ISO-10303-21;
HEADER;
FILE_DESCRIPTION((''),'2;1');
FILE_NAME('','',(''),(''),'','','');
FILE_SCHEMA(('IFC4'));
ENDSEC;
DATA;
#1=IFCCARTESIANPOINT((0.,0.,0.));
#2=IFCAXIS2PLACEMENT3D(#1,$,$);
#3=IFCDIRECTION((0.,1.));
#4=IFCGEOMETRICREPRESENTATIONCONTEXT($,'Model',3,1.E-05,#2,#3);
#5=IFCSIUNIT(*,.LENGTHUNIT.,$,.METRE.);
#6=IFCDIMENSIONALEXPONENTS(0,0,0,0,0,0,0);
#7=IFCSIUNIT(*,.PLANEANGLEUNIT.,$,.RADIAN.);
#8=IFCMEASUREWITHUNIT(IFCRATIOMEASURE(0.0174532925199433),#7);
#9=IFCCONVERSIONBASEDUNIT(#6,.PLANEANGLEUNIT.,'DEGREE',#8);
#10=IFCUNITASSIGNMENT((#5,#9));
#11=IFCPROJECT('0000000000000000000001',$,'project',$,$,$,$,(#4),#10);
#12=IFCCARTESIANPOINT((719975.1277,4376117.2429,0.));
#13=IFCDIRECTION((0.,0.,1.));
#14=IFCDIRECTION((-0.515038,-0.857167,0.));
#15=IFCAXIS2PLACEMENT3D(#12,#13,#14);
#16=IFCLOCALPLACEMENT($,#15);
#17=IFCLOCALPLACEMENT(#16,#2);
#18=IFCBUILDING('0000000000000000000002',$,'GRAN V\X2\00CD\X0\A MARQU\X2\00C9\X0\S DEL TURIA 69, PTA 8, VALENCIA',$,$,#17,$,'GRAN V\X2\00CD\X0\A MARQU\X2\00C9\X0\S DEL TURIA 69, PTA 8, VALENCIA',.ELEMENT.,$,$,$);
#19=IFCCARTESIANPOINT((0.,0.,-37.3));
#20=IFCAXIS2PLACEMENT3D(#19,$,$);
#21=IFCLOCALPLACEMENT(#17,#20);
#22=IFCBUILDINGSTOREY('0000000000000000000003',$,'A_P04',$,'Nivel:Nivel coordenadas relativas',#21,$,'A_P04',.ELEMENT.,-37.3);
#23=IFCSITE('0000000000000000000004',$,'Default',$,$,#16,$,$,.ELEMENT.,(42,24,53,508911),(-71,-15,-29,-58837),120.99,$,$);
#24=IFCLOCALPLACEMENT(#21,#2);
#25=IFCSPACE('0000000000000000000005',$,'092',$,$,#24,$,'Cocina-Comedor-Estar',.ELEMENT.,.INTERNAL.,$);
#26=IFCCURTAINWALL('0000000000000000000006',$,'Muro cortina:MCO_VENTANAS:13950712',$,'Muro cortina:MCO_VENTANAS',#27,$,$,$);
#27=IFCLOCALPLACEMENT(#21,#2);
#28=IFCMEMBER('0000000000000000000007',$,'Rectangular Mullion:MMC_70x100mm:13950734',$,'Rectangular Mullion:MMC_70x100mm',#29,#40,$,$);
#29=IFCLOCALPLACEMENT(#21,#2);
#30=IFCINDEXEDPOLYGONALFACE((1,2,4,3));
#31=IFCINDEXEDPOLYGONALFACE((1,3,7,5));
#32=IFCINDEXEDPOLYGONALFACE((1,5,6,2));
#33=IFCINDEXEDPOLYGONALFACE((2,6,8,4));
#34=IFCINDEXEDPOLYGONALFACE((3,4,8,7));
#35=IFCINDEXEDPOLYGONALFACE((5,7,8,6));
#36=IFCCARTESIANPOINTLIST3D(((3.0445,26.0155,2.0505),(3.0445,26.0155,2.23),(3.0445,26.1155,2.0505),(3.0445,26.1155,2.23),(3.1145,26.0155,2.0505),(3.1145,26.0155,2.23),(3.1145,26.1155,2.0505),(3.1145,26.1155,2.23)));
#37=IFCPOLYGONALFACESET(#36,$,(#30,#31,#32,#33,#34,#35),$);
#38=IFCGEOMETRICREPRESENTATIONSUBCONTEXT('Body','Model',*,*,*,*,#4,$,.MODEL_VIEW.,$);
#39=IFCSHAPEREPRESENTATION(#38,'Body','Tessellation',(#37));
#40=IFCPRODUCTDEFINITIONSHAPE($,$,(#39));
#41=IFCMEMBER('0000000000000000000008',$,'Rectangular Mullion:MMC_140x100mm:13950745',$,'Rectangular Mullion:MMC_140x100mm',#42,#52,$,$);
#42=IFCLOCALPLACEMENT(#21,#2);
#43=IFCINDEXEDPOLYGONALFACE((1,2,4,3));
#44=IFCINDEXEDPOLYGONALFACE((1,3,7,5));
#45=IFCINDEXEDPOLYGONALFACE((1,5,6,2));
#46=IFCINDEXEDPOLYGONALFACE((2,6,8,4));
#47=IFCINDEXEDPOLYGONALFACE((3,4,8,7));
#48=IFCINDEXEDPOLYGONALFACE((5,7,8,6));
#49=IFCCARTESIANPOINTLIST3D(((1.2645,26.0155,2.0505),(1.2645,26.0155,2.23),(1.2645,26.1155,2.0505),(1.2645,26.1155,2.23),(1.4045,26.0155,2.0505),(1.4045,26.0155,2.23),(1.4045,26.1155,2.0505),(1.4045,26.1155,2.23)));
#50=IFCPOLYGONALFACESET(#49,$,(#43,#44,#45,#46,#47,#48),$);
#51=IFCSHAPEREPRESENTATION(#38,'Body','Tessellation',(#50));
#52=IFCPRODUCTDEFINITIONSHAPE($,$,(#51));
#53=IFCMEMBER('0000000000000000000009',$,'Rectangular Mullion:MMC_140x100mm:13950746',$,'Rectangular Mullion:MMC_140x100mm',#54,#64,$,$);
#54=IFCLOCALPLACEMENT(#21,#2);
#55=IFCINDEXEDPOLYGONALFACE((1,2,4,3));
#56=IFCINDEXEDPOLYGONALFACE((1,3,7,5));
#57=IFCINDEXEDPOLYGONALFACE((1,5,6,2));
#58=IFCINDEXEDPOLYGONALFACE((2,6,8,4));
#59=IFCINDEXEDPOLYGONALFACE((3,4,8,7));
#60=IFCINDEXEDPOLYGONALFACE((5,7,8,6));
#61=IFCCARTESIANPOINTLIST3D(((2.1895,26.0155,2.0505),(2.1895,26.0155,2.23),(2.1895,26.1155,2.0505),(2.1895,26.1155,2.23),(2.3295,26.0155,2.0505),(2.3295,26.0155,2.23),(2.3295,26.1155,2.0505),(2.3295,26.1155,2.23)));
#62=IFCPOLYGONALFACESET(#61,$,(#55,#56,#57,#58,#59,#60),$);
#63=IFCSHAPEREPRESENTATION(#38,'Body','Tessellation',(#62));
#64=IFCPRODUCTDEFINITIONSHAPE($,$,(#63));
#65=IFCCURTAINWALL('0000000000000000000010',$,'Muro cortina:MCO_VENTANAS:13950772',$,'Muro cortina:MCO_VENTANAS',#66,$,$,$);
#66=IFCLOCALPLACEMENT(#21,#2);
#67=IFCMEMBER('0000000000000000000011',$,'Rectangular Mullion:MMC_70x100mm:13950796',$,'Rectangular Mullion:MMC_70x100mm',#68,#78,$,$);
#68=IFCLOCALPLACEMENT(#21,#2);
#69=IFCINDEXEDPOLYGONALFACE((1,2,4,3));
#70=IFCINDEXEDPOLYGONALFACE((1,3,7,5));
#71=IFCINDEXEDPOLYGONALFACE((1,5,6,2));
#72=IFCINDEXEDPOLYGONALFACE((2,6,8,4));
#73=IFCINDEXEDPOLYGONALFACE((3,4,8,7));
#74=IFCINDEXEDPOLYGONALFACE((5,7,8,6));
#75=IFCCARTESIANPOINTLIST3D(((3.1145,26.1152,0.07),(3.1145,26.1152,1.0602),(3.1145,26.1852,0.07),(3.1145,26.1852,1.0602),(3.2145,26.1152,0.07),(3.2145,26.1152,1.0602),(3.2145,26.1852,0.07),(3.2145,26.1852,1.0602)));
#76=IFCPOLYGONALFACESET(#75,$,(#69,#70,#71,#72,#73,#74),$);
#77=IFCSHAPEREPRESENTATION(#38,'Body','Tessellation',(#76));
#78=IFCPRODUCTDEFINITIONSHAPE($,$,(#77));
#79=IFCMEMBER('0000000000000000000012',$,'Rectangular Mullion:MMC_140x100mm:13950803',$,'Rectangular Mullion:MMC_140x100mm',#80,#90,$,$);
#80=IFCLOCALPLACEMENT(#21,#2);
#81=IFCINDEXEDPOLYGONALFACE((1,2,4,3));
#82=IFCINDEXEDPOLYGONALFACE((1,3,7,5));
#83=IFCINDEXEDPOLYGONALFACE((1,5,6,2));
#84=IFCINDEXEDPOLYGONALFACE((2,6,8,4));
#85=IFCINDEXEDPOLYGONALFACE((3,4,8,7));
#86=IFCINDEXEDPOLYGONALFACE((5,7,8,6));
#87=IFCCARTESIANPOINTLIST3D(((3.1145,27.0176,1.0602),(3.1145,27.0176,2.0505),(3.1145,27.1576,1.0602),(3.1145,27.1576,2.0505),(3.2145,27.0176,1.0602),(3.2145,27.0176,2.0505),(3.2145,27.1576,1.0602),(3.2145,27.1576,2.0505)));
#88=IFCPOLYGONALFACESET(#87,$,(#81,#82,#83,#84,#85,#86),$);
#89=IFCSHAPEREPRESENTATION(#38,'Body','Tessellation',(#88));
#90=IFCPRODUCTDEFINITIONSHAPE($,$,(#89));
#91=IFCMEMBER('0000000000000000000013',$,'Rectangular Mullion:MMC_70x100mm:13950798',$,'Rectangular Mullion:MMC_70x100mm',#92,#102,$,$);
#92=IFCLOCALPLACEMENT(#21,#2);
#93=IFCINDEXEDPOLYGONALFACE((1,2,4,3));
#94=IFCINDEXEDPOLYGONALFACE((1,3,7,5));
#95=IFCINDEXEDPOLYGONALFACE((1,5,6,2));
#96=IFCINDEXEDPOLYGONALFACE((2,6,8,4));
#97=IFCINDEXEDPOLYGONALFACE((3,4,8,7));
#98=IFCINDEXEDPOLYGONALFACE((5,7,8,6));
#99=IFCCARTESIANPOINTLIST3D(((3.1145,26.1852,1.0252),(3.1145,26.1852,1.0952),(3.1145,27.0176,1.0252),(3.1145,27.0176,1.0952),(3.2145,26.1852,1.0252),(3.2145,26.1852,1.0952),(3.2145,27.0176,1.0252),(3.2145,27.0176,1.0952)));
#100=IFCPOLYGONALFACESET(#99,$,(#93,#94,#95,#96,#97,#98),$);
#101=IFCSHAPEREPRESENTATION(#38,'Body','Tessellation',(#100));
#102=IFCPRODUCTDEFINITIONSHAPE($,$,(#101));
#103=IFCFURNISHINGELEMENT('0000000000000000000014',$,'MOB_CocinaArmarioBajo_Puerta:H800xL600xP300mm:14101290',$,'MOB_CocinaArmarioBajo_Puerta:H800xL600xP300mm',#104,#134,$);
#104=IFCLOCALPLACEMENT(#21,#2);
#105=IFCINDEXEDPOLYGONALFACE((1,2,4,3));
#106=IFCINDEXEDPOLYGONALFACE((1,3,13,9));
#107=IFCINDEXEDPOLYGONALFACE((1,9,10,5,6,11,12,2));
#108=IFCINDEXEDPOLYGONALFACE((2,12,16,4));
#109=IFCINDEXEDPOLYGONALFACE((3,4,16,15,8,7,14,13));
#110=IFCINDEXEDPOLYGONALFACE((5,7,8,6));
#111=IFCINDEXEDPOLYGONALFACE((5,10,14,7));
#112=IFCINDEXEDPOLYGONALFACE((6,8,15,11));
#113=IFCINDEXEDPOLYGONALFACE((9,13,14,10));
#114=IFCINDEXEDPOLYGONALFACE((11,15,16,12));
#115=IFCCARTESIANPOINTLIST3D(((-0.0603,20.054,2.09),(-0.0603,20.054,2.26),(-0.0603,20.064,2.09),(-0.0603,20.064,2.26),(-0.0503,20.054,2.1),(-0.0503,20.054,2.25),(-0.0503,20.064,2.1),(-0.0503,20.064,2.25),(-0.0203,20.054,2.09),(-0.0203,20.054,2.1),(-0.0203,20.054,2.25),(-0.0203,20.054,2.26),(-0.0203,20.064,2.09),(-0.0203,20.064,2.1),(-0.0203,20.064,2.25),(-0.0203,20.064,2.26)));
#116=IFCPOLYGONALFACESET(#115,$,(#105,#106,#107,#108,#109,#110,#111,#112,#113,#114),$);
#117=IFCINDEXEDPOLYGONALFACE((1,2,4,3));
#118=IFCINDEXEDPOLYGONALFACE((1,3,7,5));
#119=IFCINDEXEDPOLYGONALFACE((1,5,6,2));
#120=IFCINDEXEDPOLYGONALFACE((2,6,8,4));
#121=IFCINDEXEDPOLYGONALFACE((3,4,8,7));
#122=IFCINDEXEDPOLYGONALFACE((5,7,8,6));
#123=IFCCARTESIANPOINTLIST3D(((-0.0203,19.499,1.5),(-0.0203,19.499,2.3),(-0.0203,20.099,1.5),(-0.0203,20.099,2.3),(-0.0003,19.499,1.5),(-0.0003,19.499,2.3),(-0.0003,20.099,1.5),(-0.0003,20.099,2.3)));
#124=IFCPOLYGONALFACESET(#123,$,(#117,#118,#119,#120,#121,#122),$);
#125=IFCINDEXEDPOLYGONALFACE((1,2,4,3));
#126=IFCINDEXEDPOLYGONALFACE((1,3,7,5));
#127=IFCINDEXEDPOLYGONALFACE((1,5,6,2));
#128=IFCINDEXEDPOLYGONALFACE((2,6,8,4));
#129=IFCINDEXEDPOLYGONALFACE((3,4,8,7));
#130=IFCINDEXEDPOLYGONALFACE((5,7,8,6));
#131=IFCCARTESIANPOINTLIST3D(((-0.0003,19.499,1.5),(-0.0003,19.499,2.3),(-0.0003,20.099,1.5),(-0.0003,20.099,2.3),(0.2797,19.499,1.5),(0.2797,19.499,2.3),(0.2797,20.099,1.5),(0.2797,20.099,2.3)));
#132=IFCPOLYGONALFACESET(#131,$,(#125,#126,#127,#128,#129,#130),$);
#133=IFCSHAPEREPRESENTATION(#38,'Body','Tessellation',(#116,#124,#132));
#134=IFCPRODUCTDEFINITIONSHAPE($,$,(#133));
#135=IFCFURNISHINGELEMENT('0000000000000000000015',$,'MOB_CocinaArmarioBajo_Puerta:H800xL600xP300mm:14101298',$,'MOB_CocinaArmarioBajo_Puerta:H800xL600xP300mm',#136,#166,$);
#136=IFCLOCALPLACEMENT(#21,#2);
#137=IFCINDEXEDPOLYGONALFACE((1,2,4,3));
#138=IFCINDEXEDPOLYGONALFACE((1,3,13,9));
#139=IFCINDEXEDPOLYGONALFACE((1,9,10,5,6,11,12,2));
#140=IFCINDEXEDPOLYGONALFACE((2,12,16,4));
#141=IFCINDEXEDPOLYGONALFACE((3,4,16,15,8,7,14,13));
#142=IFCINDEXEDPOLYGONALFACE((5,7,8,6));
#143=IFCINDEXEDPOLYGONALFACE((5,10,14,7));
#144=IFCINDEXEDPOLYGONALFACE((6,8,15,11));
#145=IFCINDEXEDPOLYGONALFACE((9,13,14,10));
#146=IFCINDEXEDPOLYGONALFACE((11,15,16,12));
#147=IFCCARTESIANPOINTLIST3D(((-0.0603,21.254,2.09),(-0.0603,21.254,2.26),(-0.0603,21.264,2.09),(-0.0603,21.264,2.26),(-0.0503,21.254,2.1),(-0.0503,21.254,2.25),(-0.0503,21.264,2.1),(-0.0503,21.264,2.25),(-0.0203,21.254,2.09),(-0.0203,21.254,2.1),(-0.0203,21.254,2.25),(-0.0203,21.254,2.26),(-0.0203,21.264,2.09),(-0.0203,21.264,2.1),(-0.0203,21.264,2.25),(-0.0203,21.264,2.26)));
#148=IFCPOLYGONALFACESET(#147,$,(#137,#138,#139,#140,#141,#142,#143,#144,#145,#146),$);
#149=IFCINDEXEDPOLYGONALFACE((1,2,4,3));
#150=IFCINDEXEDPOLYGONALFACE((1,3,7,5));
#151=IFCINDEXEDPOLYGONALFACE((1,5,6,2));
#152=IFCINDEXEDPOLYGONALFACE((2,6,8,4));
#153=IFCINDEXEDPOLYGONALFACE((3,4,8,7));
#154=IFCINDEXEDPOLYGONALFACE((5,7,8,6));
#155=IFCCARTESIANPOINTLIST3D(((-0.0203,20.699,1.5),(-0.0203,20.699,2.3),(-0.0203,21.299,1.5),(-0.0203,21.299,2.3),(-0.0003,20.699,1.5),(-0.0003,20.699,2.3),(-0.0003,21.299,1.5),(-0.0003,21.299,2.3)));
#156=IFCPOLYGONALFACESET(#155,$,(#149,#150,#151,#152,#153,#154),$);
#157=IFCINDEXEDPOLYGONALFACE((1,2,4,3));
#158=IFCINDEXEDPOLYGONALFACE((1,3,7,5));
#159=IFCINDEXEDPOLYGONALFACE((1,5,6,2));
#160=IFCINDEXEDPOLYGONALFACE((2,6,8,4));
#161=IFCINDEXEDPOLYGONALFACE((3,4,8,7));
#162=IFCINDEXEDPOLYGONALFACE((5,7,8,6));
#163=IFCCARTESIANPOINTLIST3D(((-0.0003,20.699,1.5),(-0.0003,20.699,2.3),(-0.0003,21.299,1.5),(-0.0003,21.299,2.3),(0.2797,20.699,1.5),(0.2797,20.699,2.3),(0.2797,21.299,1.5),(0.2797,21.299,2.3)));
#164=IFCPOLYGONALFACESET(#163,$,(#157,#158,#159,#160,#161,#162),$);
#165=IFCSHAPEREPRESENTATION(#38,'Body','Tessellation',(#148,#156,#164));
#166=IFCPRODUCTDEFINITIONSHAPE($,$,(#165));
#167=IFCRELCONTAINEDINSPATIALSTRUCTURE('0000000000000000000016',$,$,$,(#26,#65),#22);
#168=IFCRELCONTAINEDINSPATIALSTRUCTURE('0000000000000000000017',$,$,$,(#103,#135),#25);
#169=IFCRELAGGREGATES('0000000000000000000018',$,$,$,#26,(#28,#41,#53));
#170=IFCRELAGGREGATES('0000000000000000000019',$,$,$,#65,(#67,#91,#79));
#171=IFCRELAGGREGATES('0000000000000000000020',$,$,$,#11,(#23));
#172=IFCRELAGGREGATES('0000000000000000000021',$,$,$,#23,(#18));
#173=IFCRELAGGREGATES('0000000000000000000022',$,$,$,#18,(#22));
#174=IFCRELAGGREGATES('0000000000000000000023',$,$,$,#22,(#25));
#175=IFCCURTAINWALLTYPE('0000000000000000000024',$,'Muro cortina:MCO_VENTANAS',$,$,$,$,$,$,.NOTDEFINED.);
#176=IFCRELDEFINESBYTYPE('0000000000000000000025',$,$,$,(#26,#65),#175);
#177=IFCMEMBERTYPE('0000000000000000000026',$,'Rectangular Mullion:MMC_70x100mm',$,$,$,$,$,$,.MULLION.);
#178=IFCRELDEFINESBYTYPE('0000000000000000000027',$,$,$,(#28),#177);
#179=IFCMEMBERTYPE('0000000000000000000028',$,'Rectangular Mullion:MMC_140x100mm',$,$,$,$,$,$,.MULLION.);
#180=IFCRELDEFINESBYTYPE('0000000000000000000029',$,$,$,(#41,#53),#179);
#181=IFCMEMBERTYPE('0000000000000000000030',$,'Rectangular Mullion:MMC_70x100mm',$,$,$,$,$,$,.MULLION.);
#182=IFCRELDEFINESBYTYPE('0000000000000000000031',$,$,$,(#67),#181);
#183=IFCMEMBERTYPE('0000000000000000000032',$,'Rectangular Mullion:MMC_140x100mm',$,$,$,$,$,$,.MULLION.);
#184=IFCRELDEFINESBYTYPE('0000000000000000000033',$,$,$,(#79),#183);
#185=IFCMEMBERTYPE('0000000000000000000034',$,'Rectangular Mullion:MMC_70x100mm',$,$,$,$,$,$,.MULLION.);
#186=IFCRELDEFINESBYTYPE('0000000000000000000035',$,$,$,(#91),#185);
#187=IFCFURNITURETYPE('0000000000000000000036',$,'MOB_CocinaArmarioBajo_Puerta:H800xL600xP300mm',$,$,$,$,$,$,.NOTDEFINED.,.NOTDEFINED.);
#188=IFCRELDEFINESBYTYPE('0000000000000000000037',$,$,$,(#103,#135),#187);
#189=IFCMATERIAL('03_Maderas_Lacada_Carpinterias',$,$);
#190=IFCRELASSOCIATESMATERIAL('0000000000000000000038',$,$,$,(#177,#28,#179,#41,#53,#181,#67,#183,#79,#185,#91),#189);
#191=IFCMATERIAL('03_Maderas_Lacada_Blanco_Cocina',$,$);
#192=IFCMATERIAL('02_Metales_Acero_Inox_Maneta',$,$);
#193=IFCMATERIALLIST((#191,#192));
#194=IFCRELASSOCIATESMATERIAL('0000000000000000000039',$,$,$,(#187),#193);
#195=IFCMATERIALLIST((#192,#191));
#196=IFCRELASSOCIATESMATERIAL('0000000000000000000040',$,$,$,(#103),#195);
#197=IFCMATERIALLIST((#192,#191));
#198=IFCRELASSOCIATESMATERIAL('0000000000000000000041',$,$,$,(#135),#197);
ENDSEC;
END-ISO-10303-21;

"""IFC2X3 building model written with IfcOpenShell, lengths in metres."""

from ifc_helpers import new_model, entity, si_unit, converted_unit, direction, frame, frame_2d, origin, origin_2d_with_axis, place, context, subcontext, project, spatial, polyline, rectangle, outline, extrude, source, transform, mapped, material, material_list, type_object, type_shapes, element, aggregate, save


model = new_model("IFC2X3")

# Units and contexts
model_context = context("Model", 3, precision=1e-05, world=origin(), true_north=direction((0.0, 1.0)))
body_context = subcontext(model_context, "Body", "Model", "MODEL_VIEW")
ifc_project = project(units=[si_unit("LENGTHUNIT", "METRE"), converted_unit("PLANEANGLEUNIT", "DEGREE", entity("IfcRatioMeasure", 0.0174532925199433), si_unit("PLANEANGLEUNIT", "RADIAN"), dimensions=[0, 0, 0, 0, 0, 0, 0])], contexts=[model_context])

# Site, building, storey
site_placement = place(None, frame((719975.1277, 4376117.2429, 0.0), z_axis=(0.0, 0.0, 1.0), x_axis=(-0.515038, -0.857167, 0.0)))
site = spatial("IfcSite", under=ifc_project, at=site_placement, Name="Default", CompositionType="ELEMENT", RefLatitude=(42, 24, 53, 508911), RefLongitude=(-71, -15, -29, -58837), RefElevation=120.99)
building_placement = place(site_placement, origin())
building = spatial("IfcBuilding", under=site, at=building_placement, Name="GRAN VÍA MARQUÉS DEL TURIA 69, PTA 8, VALENCIA", LongName="GRAN VÍA MARQUÉS DEL TURIA 69, PTA 8, VALENCIA", CompositionType="ELEMENT")
storey_placement = place(building_placement, frame((0.0, 0.0, -37.3)))
storey = spatial("IfcBuildingStorey", under=building, at=storey_placement, Name="A_P04", ObjectType="Nivel:Nivel coordenadas relativas", LongName="A_P04", CompositionType="ELEMENT", Elevation=-37.3)

# Curtain walls, members
curtain_wall_type = type_object("IfcCurtainWallType", Name="Muro cortina:MCO_VENTANAS", PredefinedType="NOTDEFINED")
curtain_wall_1_placement = place(storey_placement, frame((0.0, 0.0, 37.3)))
curtain_wall_1 = element("IfcCurtainWall", 1, at=curtain_wall_1_placement, inside=storey, type_object=curtain_wall_type, Name="Muro cortina:MCO_VENTANAS:13950712", ObjectType="Muro cortina:MCO_VENTANAS")
ifc_material_1 = material(Name="03_Maderas_Lacada_Carpinterias")
member_type_1 = type_object("IfcMemberType", Name="Rectangular Mullion:MMC_70x100mm", PredefinedType="MULLION", material=ifc_material_1)
shared_shape_1 = source(origin(), body_context, "Body", "SweptSolid", [
    extrude(rectangle(XDim=0.1, YDim=0.07, at=origin_2d_with_axis()), frame((-0.035, 0.0, -0.1795), z_axis=(0.0, 0.0, 1.0), x_axis=(0.0, -1.0, 0.0)), (0.0, 0.0, 1.0), 0.1795),
])
type_shapes(member_type_1, [shared_shape_1])
member_1_placement = place(storey_placement, frame((3.1145, 26.0655, 2.0505), z_axis=(0.0, 0.0, -1.0), x_axis=(1.0, 0.00001, 0.0)))
member_1 = element("IfcMember", 2, at=member_1_placement, type_object=member_type_1, material=ifc_material_1, Name="Rectangular Mullion:MMC_70x100mm:13950734", ObjectType="Rectangular Mullion:MMC_70x100mm", context=body_context, shape_type="MappedRepresentation", body=[
    mapped(shared_shape_1, transform((0.0, 0.0, 0.0), scale=1.0)),
])
member_type_2 = type_object("IfcMemberType", Name="Rectangular Mullion:MMC_140x100mm", PredefinedType="MULLION", material=ifc_material_1)
shared_shape_2 = source(origin(), body_context, "Body", "SweptSolid", [
    extrude(rectangle(XDim=0.1, YDim=0.14, at=origin_2d_with_axis()), frame((0.0, 0.0, -0.1795), z_axis=(0.0, 0.0, 1.0), x_axis=(0.0, -1.0, 0.0)), (0.0, 0.0, 1.0), 0.1795),
])
type_shapes(member_type_2, [shared_shape_2])
member_2_placement = place(storey_placement, frame((1.3345, 26.0655, 2.0505), z_axis=(0.0, 0.0, -1.0), x_axis=(1.0, 0.00001, 0.0)))
member_2 = element("IfcMember", 3, at=member_2_placement, type_object=member_type_2, material=ifc_material_1, Name="Rectangular Mullion:MMC_140x100mm:13950745", ObjectType="Rectangular Mullion:MMC_140x100mm", context=body_context, shape_type="MappedRepresentation", body=[
    mapped(shared_shape_2, transform((0.0, 0.0, 0.0), scale=1.0)),
])
member_3_placement = place(storey_placement, frame((2.2595, 26.0655, 2.0505), z_axis=(0.0, 0.0, -1.0), x_axis=(1.0, 0.00001, 0.0)))
member_3 = element("IfcMember", 4, at=member_3_placement, type_object=member_type_2, material=ifc_material_1, Name="Rectangular Mullion:MMC_140x100mm:13950746", ObjectType="Rectangular Mullion:MMC_140x100mm", context=body_context, shape_type="MappedRepresentation", body=[
    mapped(shared_shape_2, transform((0.0, 0.0, 0.0), scale=1.0)),
])
curtain_wall_2_placement = place(storey_placement, frame((0.0, 0.0, 37.3)))
curtain_wall_2 = element("IfcCurtainWall", 5, at=curtain_wall_2_placement, inside=storey, type_object=curtain_wall_type, Name="Muro cortina:MCO_VENTANAS:13950772", ObjectType="Muro cortina:MCO_VENTANAS")
member_type_3 = type_object("IfcMemberType", Name="Rectangular Mullion:MMC_70x100mm", PredefinedType="MULLION", material=ifc_material_1)
shared_shape_3 = source(origin(), body_context, "Body", "SweptSolid", [
    extrude(rectangle(XDim=0.1, YDim=0.07, at=origin_2d_with_axis()), frame((-0.035, 0.0, -0.9902), z_axis=(0.0, 0.0, 1.0), x_axis=(0.0, -1.0, 0.0)), (0.0, 0.0, 1.0), 0.9902),
])
type_shapes(member_type_3, [shared_shape_3])
member_4_placement = place(storey_placement, frame((3.1645, 26.1152, 1.0602), z_axis=(0.0, 0.0, 1.0), x_axis=(0.00001, -1.0, 0.0)))
member_4 = element("IfcMember", 6, at=member_4_placement, type_object=member_type_3, material=ifc_material_1, Name="Rectangular Mullion:MMC_70x100mm:13950796", ObjectType="Rectangular Mullion:MMC_70x100mm", context=body_context, shape_type="MappedRepresentation", body=[
    mapped(shared_shape_3, transform((0.0, 0.0, 0.0), scale=1.0)),
])
member_type_4 = type_object("IfcMemberType", Name="Rectangular Mullion:MMC_140x100mm", PredefinedType="MULLION", material=ifc_material_1)
shared_shape_4 = source(origin(), body_context, "Body", "SweptSolid", [
    extrude(rectangle(XDim=0.1, YDim=0.14, at=origin_2d_with_axis()), frame((0.0, 0.0, -0.9902), z_axis=(0.0, 0.0, 1.0), x_axis=(0.0, -1.0, 0.0)), (0.0, 0.0, 1.0), 0.9902),
])
type_shapes(member_type_4, [shared_shape_4])
member_5_placement = place(storey_placement, frame((3.1645, 27.0876, 1.0602), z_axis=(0.0, 0.0, -1.0), x_axis=(-0.00001, 1.0, 0.0)))
member_5 = element("IfcMember", 7, at=member_5_placement, type_object=member_type_4, material=ifc_material_1, Name="Rectangular Mullion:MMC_140x100mm:13950803", ObjectType="Rectangular Mullion:MMC_140x100mm", context=body_context, shape_type="MappedRepresentation", body=[
    mapped(shared_shape_4, transform((0.0, 0.0, 0.0), scale=1.0)),
])
member_type_5 = type_object("IfcMemberType", Name="Rectangular Mullion:MMC_70x100mm", PredefinedType="MULLION", material=ifc_material_1)
shared_shape_5 = source(origin(), body_context, "Body", "SweptSolid", [
    extrude(rectangle(XDim=0.1, YDim=0.07, at=origin_2d_with_axis()), frame((0.0, 0.0, -0.8323), z_axis=(0.0, 0.0, 1.0), x_axis=(0.0, -1.0, 0.0)), (0.0, 0.0, 1.0), 0.8323),
])
type_shapes(member_type_5, [shared_shape_5])
member_6_placement = place(storey_placement, frame((3.1645, 27.0176, 1.0602), z_axis=(-0.00001, 1.0, 0.0), x_axis=(0.0, 0.0, 1.0)))
member_6 = element("IfcMember", 8, at=member_6_placement, type_object=member_type_5, material=ifc_material_1, Name="Rectangular Mullion:MMC_70x100mm:13950798", ObjectType="Rectangular Mullion:MMC_70x100mm", context=body_context, shape_type="MappedRepresentation", body=[
    mapped(shared_shape_5, transform((0.0, 0.0, 0.0), scale=1.0)),
])

aggregate(curtain_wall_1, [member_1, member_2, member_3])
aggregate(curtain_wall_2, [member_4, member_6, member_5])

# Shared definitions
space_1_placement = place(storey_placement, origin())
space_1 = spatial("IfcSpace", under=storey, at=space_1_placement, Name="092", LongName="Cocina-Comedor-Estar", CompositionType="ELEMENT", InteriorOrExteriorSpace="INTERNAL")

# Furnishing elements
ifc_material_2 = material(Name="02_Metales_Acero_Inox_Maneta")
ifc_material_3 = material(Name="03_Maderas_Lacada_Blanco_Cocina")
ifc_material_list_1 = material_list([ifc_material_2, ifc_material_3])
ifc_material_list_2 = material_list([ifc_material_3, ifc_material_2])
furniture_type_1 = type_object("IfcFurnitureType", Name="MOB_CocinaArmarioBajo_Puerta:H800xL600xP300mm", material=ifc_material_list_2)
shared_shape_6 = source(origin(), body_context, "Body", "SweptSolid", [
    extrude(outline(polyline([(-0.0175, -0.075), (-0.0175, -0.085), (0.0225, -0.085), (0.0225, 0.085), (-0.0175, 0.085), (-0.0175, 0.075), (0.0125, 0.075), (0.0125, -0.075), (-0.0175, -0.075)])), frame((-0.265, -0.3175, 0.675), z_axis=(-1.0, 0.0, 0.0), x_axis=(0.0, -1.0, 0.0)), (0.0, 0.0, -1.0), 0.01),
    extrude(rectangle(XDim=0.6, YDim=0.02, at=frame_2d((0.0, 0.0), x_axis=(1.0, 0.0))), frame((0.0, -0.29, 0.0)), (0.0, 0.0, 1.0), 0.8),
    extrude(rectangle(XDim=0.28, YDim=0.6, at=origin_2d_with_axis()), frame((0.0, -0.14, 0.0), z_axis=(0.0, 0.0, 1.0), x_axis=(0.0, -1.0, 0.0)), (0.0, 0.0, 1.0), 0.8),
])
type_shapes(furniture_type_1, [shared_shape_6])
furnishing_1_placement = place(space_1_placement, frame((0.2797, 19.799, 1.5), z_axis=(0.0, 0.0, 1.0), x_axis=(0.0, -1.0, 0.0)))
element("IfcFurnishingElement", 9, at=furnishing_1_placement, inside=space_1, type_object=furniture_type_1, material=ifc_material_list_1, Name="MOB_CocinaArmarioBajo_Puerta:H800xL600xP300mm:14101290", ObjectType="MOB_CocinaArmarioBajo_Puerta:H800xL600xP300mm", context=body_context, shape_type="MappedRepresentation", body=[
    mapped(shared_shape_6, transform((0.0, 0.0, 0.0), scale=1.0)),
])
ifc_material_list_3 = material_list([ifc_material_2, ifc_material_3])
furnishing_2_placement = place(space_1_placement, frame((0.2797, 20.999, 1.5), z_axis=(0.0, 0.0, 1.0), x_axis=(0.0, -1.0, 0.0)))
element("IfcFurnishingElement", 10, at=furnishing_2_placement, inside=space_1, type_object=furniture_type_1, material=ifc_material_list_3, Name="MOB_CocinaArmarioBajo_Puerta:H800xL600xP300mm:14101298", ObjectType="MOB_CocinaArmarioBajo_Puerta:H800xL600xP300mm", context=body_context, shape_type="MappedRepresentation", body=[
    mapped(shared_shape_6, transform((0.0, 0.0, 0.0), scale=1.0)),
])

save(model, "model.ifc")
